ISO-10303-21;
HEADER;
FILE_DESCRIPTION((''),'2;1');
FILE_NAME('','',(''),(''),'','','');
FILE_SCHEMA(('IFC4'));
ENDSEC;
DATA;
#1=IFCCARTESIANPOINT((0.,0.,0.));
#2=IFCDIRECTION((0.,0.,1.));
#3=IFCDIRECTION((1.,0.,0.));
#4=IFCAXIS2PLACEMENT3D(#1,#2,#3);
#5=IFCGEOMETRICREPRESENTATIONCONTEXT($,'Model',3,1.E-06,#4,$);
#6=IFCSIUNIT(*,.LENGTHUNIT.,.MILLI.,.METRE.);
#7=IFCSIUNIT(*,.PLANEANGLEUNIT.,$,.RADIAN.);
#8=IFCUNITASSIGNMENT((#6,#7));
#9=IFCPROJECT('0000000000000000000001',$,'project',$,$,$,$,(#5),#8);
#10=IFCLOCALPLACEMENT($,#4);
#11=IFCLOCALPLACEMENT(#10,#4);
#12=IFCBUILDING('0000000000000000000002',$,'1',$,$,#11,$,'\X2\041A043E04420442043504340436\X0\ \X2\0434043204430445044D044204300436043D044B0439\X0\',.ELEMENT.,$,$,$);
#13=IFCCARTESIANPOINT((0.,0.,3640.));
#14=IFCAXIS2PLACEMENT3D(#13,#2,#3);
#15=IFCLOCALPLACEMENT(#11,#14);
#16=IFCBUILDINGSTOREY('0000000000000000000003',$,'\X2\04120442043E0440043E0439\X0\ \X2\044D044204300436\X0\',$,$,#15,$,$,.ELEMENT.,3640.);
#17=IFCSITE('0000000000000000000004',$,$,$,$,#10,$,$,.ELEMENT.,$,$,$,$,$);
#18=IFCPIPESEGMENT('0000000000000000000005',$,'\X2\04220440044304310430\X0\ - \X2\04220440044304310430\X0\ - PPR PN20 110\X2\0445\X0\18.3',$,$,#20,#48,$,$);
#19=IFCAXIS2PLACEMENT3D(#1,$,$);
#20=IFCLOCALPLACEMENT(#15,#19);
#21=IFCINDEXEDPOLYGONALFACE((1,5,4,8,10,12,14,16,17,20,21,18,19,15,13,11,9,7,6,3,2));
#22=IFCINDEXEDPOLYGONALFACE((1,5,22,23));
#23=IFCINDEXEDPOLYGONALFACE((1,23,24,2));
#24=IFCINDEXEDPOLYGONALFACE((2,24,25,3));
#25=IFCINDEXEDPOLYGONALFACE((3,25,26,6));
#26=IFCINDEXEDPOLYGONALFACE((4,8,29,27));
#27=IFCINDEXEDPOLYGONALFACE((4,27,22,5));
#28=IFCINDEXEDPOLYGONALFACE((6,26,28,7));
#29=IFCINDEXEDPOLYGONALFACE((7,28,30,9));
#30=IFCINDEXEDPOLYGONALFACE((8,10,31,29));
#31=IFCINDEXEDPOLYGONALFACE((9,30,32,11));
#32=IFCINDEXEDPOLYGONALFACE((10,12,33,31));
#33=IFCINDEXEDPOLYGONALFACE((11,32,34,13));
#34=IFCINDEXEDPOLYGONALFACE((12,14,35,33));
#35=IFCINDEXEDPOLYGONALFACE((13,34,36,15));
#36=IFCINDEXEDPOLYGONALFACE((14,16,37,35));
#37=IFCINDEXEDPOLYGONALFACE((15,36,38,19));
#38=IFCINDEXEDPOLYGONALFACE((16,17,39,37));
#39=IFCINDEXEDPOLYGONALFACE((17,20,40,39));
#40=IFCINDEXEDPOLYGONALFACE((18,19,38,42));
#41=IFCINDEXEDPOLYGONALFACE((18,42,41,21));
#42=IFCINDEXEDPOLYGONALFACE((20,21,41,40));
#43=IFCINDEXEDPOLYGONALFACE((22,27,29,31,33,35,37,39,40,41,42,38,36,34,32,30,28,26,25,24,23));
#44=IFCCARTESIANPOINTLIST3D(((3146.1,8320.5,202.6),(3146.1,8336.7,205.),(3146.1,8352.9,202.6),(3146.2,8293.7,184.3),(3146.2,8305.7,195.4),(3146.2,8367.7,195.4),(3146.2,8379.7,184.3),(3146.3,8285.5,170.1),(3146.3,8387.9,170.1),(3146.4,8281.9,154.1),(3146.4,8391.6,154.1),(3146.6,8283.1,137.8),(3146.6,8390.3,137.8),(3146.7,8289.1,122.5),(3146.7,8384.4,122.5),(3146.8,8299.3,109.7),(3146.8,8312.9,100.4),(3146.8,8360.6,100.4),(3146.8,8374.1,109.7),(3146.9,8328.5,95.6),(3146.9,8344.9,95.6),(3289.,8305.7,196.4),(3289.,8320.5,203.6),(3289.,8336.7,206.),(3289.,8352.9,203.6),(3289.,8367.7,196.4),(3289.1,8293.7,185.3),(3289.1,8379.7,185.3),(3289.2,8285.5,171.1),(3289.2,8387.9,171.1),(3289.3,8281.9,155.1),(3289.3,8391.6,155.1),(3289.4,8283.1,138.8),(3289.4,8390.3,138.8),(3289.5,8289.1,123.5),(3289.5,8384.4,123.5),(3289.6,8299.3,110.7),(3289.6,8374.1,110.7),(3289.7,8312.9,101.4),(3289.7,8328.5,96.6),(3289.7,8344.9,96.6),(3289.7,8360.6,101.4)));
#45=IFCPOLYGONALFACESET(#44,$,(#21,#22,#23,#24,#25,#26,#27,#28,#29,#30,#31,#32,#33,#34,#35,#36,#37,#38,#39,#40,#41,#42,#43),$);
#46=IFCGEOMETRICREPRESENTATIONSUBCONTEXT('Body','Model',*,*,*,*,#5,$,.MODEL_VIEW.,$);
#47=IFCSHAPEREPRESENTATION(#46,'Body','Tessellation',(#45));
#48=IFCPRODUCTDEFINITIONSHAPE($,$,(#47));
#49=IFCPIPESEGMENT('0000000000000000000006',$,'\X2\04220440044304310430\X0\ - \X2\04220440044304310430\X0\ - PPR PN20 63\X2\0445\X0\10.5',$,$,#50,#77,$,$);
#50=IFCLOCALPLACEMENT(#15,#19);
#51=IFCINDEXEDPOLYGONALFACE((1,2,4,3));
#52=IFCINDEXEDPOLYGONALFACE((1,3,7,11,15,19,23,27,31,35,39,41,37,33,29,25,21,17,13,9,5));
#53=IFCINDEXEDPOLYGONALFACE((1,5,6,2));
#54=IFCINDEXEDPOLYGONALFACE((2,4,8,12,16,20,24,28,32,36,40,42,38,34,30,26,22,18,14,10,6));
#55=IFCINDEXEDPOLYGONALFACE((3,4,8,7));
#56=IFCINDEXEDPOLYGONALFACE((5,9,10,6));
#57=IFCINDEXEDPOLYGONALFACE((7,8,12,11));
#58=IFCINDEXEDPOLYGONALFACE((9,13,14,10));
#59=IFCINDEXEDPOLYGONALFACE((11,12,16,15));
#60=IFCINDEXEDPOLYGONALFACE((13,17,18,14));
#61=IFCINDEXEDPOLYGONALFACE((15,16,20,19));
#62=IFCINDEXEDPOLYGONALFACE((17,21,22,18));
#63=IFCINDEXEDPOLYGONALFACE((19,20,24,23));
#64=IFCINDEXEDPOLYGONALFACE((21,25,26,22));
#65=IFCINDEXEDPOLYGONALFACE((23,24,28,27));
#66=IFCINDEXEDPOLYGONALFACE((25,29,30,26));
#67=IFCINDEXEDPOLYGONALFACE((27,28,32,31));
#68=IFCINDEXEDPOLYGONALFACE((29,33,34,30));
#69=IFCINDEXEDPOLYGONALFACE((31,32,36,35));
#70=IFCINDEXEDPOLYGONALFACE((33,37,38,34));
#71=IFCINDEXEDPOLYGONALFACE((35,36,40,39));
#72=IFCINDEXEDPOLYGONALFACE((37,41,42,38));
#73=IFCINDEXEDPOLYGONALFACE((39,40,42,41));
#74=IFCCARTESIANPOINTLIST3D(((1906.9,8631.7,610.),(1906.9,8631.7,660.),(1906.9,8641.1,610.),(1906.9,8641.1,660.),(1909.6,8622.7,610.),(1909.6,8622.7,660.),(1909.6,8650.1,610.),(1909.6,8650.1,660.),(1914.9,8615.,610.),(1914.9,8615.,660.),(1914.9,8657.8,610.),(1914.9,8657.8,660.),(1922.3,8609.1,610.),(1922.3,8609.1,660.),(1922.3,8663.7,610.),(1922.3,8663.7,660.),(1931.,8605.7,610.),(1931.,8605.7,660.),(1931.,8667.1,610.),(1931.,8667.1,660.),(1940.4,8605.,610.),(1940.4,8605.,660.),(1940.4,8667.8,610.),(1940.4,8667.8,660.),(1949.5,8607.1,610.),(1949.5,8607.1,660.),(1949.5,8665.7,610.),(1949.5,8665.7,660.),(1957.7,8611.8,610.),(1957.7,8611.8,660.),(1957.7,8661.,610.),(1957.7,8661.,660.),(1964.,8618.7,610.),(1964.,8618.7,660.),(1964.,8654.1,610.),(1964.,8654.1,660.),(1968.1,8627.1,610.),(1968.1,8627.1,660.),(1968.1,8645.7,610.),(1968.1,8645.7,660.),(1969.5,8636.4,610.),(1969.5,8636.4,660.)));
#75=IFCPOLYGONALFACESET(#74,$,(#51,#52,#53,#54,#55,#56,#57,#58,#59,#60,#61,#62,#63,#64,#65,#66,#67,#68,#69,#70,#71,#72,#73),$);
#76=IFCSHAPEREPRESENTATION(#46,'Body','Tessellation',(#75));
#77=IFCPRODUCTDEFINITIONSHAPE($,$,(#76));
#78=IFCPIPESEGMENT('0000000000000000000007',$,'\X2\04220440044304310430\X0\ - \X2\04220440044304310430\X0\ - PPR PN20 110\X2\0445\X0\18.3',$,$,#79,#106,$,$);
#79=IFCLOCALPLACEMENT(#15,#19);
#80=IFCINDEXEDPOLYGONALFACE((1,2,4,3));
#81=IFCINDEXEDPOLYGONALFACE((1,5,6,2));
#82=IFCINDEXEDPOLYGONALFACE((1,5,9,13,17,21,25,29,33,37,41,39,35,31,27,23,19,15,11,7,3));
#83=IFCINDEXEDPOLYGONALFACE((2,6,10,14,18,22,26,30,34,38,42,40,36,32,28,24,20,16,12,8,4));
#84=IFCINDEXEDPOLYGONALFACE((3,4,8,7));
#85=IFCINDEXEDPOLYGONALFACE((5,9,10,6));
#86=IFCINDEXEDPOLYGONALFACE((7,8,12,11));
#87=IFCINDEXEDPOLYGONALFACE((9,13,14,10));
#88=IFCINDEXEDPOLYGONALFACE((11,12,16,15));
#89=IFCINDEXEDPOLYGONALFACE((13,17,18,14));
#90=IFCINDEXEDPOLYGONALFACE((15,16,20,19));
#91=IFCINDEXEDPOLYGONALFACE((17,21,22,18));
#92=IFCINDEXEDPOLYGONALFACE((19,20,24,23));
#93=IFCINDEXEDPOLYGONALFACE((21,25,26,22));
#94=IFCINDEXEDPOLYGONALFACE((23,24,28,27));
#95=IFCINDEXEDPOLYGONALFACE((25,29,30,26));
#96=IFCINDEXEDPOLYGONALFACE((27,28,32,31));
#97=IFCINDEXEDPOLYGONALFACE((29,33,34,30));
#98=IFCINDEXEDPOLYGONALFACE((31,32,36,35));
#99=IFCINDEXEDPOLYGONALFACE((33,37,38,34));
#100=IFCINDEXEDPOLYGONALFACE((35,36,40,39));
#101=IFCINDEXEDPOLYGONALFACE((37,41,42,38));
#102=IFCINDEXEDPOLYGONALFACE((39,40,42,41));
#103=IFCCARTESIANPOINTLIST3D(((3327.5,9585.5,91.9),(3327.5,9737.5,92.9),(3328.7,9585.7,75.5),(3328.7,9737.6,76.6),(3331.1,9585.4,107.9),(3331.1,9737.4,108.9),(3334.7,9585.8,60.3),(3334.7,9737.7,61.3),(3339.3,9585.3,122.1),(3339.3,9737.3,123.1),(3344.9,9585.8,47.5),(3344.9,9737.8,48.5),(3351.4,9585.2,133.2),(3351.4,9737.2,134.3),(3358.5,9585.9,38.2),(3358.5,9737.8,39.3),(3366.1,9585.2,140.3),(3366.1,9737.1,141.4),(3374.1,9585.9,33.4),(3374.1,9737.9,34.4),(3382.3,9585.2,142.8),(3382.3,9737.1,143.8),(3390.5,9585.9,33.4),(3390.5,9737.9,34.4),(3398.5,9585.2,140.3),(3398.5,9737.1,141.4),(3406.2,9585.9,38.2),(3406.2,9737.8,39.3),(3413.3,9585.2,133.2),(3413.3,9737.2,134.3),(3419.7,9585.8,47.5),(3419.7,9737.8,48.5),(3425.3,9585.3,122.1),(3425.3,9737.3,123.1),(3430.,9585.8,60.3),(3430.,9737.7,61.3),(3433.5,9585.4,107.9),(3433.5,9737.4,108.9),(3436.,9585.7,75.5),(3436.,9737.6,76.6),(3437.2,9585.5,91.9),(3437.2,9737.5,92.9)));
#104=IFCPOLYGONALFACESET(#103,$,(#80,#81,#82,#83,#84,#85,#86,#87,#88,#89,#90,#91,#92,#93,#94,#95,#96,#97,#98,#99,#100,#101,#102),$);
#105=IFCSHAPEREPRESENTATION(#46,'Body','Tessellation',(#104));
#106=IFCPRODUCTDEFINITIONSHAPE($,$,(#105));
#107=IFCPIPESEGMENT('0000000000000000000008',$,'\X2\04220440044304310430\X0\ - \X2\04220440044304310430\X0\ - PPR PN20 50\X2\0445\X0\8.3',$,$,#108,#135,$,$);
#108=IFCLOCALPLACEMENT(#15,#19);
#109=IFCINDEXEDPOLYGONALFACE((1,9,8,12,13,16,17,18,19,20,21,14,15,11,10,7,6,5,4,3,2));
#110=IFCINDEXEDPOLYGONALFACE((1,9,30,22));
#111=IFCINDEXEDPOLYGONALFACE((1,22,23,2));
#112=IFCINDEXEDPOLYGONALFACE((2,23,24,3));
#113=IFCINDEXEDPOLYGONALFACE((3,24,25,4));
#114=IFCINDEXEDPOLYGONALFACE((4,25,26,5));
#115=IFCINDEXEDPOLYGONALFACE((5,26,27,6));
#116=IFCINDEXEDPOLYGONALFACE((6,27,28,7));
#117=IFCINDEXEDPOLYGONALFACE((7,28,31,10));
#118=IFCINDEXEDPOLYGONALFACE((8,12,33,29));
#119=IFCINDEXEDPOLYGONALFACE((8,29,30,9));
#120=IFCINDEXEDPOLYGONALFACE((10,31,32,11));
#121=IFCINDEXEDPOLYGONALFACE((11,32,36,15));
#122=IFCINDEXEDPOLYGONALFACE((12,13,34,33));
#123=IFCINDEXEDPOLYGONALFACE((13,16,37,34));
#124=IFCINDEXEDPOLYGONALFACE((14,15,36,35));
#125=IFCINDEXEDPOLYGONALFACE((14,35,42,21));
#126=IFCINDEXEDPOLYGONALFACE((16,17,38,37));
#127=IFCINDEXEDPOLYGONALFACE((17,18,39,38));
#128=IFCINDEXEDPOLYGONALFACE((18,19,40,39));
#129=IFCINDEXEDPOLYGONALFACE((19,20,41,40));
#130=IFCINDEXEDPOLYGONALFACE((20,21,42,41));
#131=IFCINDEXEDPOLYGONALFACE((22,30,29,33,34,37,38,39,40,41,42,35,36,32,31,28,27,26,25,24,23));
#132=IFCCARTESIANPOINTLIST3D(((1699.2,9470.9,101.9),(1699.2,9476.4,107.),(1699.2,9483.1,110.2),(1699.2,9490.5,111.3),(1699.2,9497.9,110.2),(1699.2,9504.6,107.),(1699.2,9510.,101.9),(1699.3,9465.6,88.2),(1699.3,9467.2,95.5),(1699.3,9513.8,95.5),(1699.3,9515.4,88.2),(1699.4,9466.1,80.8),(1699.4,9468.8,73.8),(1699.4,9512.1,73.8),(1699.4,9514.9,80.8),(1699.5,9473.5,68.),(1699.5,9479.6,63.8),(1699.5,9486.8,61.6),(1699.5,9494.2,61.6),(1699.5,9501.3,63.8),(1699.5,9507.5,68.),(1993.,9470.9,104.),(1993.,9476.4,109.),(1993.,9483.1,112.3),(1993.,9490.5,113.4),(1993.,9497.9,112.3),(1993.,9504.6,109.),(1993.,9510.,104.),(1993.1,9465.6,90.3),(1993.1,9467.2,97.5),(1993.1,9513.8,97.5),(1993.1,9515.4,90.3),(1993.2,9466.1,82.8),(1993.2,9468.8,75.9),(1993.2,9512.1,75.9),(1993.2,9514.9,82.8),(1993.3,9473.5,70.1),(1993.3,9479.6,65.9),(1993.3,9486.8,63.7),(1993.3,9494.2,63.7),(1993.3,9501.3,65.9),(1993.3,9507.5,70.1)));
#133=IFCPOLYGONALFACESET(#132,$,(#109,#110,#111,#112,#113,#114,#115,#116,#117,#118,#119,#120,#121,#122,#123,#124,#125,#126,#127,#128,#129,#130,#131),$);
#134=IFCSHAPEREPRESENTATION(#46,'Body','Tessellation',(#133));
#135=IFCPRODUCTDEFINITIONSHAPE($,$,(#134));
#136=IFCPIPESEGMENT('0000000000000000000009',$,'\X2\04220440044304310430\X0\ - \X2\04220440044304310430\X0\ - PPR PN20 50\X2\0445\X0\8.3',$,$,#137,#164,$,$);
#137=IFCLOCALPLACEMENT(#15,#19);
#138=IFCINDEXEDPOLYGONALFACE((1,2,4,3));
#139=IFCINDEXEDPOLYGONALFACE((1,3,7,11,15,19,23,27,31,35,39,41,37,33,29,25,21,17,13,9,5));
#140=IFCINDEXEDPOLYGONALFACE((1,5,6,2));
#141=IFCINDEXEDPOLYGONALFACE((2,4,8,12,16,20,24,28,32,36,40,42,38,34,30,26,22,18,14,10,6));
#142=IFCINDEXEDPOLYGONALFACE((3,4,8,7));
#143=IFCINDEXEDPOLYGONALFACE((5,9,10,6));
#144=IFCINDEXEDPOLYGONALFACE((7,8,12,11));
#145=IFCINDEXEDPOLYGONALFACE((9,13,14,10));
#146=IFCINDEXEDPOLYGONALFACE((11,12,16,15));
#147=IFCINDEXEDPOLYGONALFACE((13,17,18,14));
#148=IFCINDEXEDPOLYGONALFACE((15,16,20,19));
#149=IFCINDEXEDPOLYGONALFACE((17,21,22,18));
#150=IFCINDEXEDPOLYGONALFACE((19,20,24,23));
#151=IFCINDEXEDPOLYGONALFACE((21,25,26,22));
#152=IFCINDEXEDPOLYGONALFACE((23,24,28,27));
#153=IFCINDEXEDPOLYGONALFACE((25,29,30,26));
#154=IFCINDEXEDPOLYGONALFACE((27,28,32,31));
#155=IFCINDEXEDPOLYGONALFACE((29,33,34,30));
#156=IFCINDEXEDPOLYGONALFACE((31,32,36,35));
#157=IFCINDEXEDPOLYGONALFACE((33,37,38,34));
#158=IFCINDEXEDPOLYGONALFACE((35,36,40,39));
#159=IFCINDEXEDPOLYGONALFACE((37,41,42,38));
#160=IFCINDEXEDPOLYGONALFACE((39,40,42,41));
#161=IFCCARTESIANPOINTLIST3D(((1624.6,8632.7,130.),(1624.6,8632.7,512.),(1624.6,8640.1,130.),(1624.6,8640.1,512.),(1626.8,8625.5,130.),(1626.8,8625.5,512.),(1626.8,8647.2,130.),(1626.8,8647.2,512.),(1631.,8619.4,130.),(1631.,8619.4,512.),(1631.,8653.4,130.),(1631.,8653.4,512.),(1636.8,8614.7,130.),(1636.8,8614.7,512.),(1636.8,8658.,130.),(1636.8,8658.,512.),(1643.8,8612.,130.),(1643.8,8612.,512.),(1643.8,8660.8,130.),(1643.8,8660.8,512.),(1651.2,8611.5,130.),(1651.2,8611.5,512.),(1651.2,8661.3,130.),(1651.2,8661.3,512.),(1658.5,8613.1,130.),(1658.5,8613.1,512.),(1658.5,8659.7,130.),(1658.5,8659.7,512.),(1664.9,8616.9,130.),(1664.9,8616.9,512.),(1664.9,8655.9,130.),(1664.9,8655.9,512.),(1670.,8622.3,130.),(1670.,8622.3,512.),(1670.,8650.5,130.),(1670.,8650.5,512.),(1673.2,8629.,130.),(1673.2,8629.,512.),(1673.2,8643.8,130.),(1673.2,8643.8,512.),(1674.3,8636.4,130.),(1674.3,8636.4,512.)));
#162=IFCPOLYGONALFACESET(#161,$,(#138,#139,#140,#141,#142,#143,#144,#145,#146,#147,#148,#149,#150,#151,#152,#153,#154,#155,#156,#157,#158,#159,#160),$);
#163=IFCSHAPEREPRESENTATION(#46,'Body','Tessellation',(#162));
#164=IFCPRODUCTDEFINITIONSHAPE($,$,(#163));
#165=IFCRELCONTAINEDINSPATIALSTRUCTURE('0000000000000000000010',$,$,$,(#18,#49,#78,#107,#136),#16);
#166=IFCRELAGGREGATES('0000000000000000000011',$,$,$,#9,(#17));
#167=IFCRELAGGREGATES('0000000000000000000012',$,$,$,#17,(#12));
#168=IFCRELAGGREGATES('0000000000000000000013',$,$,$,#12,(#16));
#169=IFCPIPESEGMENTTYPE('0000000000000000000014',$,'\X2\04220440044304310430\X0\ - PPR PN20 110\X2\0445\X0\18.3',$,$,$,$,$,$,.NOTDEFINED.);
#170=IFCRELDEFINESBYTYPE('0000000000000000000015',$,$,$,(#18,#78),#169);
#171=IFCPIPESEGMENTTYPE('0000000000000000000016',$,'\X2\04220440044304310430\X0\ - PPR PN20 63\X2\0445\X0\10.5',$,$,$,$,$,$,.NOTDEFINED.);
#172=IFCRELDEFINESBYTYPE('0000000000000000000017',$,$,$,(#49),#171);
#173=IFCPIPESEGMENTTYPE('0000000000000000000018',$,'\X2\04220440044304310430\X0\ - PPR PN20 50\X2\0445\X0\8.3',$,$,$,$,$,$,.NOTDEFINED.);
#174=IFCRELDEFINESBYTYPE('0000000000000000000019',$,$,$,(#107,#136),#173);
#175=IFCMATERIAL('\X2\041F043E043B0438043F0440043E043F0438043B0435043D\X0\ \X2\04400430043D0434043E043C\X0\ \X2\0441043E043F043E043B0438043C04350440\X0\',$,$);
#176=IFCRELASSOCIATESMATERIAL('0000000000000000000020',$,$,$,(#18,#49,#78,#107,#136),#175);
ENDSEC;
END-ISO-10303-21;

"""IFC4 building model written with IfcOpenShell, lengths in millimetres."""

from ifc_helpers import new_model, entity, si_unit, frame, origin_with_axes, place, context, subcontext, project, spatial, source, transform, mapped, material, type_object, element, save


model = new_model("IFC4")

# Units and contexts
model_context = context("Model", 3, precision=1e-06, world=origin_with_axes())
body_context = subcontext(model_context, "Body", "Model", "MODEL_VIEW")
ifc_project = project(units=[si_unit("LENGTHUNIT", "METRE", prefix="MILLI"), si_unit("PLANEANGLEUNIT", "RADIAN")], contexts=[model_context])

# Site, building, storey
site_placement = place(None, origin_with_axes())
site = spatial("IfcSite", under=ifc_project, at=site_placement, CompositionType="ELEMENT")
building_placement = place(site_placement, origin_with_axes())
building = spatial("IfcBuilding", under=site, at=building_placement, Name="1", LongName="Коттедж двухэтажный", CompositionType="ELEMENT")
storey_placement = place(building_placement, frame((0.0, 0.0, 3640.0), z_axis=(0.0, 0.0, 1.0), x_axis=(1.0, 0.0, 0.0)))
storey = spatial("IfcBuildingStorey", under=building, at=storey_placement, Name="Второй этаж", CompositionType="ELEMENT", Elevation=3640.0)

# Pipe segments
ifc_material = material(Name="Полипропилен рандом сополимер")
pipe_segment_type_1 = type_object("IfcPipeSegmentType", Name="Труба - PPR PN20 110х18.3", PredefinedType="NOTDEFINED")
shared_shape_1 = source(origin_with_axes(), body_context, "Body", "AdvancedSweptSolid", [
    entity("IfcSweptDiskSolid", entity("IfcIndexedPolyCurve", entity("IfcCartesianPointList3D", [[0.0, 0.0, 0.0], [142.9, 0.0, 1.0]]), [entity("IfcLineIndex", [1, 2])]), 55.0),
])
pipe_segment_1_placement = place(storey_placement, frame((3146.5, 8336.7, 150.0), z_axis=(0.0, 0.0, 1.0), x_axis=(1.0, 0.0, 0.0)))
element("IfcPipeSegment", 1, at=pipe_segment_1_placement, inside=storey, type_object=pipe_segment_type_1, material=ifc_material, Name="Труба - Труба - PPR PN20 110х18.3", context=body_context, shape_type="MappedRepresentation", body=[
    mapped(shared_shape_1, transform((0.0, 0.0, 0.0), x_axis=(1.0, 0.0, 0.0), y_axis=(0.0, 1.0, 0.0), z_axis=(0.0, 0.0, 1.0), scale=1.0)),
])
pipe_segment_type_2 = type_object("IfcPipeSegmentType", Name="Труба - PPR PN20 63х10.5", PredefinedType="NOTDEFINED")
shared_shape_2 = source(origin_with_axes(), body_context, "Body", "AdvancedSweptSolid", [
    entity("IfcSweptDiskSolid", entity("IfcIndexedPolyCurve", entity("IfcCartesianPointList3D", [[0.0, 0.0, 0.0], [0.0, 0.0, 50.0]]), [entity("IfcLineIndex", [1, 2])]), 31.5),
])
pipe_segment_2_placement = place(storey_placement, frame((1938.0, 8636.4, 660.0), z_axis=(0.0, 0.0, -1.0), x_axis=(1.0, 0.0, 0.0)))
element("IfcPipeSegment", 2, at=pipe_segment_2_placement, inside=storey, type_object=pipe_segment_type_2, material=ifc_material, Name="Труба - Труба - PPR PN20 63х10.5", context=body_context, shape_type="MappedRepresentation", body=[
    mapped(shared_shape_2, transform((0.0, 0.0, 0.0), x_axis=(1.0, 0.0, 0.0), y_axis=(0.0, 1.0, 0.0), z_axis=(0.0, 0.0, 1.0), scale=1.0)),
])
shared_shape_3 = source(origin_with_axes(), body_context, "Body", "AdvancedSweptSolid", [
    entity("IfcSweptDiskSolid", entity("IfcIndexedPolyCurve", entity("IfcCartesianPointList3D", [[0.0, 0.0, 0.0], [151.9, 0.0, 1.1]]), [entity("IfcLineIndex", [1, 2])]), 55.0),
])
pipe_segment_3_placement = place(storey_placement, frame((3382.3, 9585.6, 87.8), z_axis=(0.0, 0.0, 1.0), x_axis=(0.0, 1.0, 0.0)))
element("IfcPipeSegment", 3, at=pipe_segment_3_placement, inside=storey, type_object=pipe_segment_type_1, material=ifc_material, Name="Труба - Труба - PPR PN20 110х18.3", context=body_context, shape_type="MappedRepresentation", body=[
    mapped(shared_shape_3, transform((0.0, 0.0, 0.0), x_axis=(1.0, 0.0, 0.0), y_axis=(0.0, 1.0, 0.0), z_axis=(0.0, 0.0, 1.0), scale=1.0)),
])
pipe_segment_type_3 = type_object("IfcPipeSegmentType", Name="Труба - PPR PN20 50х8.3", PredefinedType="NOTDEFINED")
shared_shape_4 = source(origin_with_axes(), body_context, "Body", "AdvancedSweptSolid", [
    entity("IfcSweptDiskSolid", entity("IfcIndexedPolyCurve", entity("IfcCartesianPointList3D", [[0.0, 0.0, 0.0], [293.8, 0.0, 2.1]]), [entity("IfcLineIndex", [1, 2])]), 25.0),
])
pipe_segment_4_placement = place(storey_placement, frame((1699.3, 9490.5, 86.3), z_axis=(0.0, 0.0, 1.0), x_axis=(1.0, 0.0, 0.0)))
element("IfcPipeSegment", 4, at=pipe_segment_4_placement, inside=storey, type_object=pipe_segment_type_3, material=ifc_material, Name="Труба - Труба - PPR PN20 50х8.3", context=body_context, shape_type="MappedRepresentation", body=[
    mapped(shared_shape_4, transform((0.0, 0.0, 0.0), x_axis=(1.0, 0.0, 0.0), y_axis=(0.0, 1.0, 0.0), z_axis=(0.0, 0.0, 1.0), scale=1.0)),
])
shared_shape_5 = source(origin_with_axes(), body_context, "Body", "AdvancedSweptSolid", [
    entity("IfcSweptDiskSolid", entity("IfcIndexedPolyCurve", entity("IfcCartesianPointList3D", [[0.0, 0.0, 0.0], [0.0, 0.0, 382.0]]), [entity("IfcLineIndex", [1, 2])]), 25.0),
])
pipe_segment_5_placement = place(storey_placement, frame((1649.3, 8636.4, 512.0), z_axis=(0.0, 0.0, -1.0), x_axis=(1.0, 0.0, 0.0)))
element("IfcPipeSegment", 5, at=pipe_segment_5_placement, inside=storey, type_object=pipe_segment_type_3, material=ifc_material, Name="Труба - Труба - PPR PN20 50х8.3", context=body_context, shape_type="MappedRepresentation", body=[
    mapped(shared_shape_5, transform((0.0, 0.0, 0.0), x_axis=(1.0, 0.0, 0.0), y_axis=(0.0, 1.0, 0.0), z_axis=(0.0, 0.0, 1.0), scale=1.0)),
])

save(model, "model.ifc")
